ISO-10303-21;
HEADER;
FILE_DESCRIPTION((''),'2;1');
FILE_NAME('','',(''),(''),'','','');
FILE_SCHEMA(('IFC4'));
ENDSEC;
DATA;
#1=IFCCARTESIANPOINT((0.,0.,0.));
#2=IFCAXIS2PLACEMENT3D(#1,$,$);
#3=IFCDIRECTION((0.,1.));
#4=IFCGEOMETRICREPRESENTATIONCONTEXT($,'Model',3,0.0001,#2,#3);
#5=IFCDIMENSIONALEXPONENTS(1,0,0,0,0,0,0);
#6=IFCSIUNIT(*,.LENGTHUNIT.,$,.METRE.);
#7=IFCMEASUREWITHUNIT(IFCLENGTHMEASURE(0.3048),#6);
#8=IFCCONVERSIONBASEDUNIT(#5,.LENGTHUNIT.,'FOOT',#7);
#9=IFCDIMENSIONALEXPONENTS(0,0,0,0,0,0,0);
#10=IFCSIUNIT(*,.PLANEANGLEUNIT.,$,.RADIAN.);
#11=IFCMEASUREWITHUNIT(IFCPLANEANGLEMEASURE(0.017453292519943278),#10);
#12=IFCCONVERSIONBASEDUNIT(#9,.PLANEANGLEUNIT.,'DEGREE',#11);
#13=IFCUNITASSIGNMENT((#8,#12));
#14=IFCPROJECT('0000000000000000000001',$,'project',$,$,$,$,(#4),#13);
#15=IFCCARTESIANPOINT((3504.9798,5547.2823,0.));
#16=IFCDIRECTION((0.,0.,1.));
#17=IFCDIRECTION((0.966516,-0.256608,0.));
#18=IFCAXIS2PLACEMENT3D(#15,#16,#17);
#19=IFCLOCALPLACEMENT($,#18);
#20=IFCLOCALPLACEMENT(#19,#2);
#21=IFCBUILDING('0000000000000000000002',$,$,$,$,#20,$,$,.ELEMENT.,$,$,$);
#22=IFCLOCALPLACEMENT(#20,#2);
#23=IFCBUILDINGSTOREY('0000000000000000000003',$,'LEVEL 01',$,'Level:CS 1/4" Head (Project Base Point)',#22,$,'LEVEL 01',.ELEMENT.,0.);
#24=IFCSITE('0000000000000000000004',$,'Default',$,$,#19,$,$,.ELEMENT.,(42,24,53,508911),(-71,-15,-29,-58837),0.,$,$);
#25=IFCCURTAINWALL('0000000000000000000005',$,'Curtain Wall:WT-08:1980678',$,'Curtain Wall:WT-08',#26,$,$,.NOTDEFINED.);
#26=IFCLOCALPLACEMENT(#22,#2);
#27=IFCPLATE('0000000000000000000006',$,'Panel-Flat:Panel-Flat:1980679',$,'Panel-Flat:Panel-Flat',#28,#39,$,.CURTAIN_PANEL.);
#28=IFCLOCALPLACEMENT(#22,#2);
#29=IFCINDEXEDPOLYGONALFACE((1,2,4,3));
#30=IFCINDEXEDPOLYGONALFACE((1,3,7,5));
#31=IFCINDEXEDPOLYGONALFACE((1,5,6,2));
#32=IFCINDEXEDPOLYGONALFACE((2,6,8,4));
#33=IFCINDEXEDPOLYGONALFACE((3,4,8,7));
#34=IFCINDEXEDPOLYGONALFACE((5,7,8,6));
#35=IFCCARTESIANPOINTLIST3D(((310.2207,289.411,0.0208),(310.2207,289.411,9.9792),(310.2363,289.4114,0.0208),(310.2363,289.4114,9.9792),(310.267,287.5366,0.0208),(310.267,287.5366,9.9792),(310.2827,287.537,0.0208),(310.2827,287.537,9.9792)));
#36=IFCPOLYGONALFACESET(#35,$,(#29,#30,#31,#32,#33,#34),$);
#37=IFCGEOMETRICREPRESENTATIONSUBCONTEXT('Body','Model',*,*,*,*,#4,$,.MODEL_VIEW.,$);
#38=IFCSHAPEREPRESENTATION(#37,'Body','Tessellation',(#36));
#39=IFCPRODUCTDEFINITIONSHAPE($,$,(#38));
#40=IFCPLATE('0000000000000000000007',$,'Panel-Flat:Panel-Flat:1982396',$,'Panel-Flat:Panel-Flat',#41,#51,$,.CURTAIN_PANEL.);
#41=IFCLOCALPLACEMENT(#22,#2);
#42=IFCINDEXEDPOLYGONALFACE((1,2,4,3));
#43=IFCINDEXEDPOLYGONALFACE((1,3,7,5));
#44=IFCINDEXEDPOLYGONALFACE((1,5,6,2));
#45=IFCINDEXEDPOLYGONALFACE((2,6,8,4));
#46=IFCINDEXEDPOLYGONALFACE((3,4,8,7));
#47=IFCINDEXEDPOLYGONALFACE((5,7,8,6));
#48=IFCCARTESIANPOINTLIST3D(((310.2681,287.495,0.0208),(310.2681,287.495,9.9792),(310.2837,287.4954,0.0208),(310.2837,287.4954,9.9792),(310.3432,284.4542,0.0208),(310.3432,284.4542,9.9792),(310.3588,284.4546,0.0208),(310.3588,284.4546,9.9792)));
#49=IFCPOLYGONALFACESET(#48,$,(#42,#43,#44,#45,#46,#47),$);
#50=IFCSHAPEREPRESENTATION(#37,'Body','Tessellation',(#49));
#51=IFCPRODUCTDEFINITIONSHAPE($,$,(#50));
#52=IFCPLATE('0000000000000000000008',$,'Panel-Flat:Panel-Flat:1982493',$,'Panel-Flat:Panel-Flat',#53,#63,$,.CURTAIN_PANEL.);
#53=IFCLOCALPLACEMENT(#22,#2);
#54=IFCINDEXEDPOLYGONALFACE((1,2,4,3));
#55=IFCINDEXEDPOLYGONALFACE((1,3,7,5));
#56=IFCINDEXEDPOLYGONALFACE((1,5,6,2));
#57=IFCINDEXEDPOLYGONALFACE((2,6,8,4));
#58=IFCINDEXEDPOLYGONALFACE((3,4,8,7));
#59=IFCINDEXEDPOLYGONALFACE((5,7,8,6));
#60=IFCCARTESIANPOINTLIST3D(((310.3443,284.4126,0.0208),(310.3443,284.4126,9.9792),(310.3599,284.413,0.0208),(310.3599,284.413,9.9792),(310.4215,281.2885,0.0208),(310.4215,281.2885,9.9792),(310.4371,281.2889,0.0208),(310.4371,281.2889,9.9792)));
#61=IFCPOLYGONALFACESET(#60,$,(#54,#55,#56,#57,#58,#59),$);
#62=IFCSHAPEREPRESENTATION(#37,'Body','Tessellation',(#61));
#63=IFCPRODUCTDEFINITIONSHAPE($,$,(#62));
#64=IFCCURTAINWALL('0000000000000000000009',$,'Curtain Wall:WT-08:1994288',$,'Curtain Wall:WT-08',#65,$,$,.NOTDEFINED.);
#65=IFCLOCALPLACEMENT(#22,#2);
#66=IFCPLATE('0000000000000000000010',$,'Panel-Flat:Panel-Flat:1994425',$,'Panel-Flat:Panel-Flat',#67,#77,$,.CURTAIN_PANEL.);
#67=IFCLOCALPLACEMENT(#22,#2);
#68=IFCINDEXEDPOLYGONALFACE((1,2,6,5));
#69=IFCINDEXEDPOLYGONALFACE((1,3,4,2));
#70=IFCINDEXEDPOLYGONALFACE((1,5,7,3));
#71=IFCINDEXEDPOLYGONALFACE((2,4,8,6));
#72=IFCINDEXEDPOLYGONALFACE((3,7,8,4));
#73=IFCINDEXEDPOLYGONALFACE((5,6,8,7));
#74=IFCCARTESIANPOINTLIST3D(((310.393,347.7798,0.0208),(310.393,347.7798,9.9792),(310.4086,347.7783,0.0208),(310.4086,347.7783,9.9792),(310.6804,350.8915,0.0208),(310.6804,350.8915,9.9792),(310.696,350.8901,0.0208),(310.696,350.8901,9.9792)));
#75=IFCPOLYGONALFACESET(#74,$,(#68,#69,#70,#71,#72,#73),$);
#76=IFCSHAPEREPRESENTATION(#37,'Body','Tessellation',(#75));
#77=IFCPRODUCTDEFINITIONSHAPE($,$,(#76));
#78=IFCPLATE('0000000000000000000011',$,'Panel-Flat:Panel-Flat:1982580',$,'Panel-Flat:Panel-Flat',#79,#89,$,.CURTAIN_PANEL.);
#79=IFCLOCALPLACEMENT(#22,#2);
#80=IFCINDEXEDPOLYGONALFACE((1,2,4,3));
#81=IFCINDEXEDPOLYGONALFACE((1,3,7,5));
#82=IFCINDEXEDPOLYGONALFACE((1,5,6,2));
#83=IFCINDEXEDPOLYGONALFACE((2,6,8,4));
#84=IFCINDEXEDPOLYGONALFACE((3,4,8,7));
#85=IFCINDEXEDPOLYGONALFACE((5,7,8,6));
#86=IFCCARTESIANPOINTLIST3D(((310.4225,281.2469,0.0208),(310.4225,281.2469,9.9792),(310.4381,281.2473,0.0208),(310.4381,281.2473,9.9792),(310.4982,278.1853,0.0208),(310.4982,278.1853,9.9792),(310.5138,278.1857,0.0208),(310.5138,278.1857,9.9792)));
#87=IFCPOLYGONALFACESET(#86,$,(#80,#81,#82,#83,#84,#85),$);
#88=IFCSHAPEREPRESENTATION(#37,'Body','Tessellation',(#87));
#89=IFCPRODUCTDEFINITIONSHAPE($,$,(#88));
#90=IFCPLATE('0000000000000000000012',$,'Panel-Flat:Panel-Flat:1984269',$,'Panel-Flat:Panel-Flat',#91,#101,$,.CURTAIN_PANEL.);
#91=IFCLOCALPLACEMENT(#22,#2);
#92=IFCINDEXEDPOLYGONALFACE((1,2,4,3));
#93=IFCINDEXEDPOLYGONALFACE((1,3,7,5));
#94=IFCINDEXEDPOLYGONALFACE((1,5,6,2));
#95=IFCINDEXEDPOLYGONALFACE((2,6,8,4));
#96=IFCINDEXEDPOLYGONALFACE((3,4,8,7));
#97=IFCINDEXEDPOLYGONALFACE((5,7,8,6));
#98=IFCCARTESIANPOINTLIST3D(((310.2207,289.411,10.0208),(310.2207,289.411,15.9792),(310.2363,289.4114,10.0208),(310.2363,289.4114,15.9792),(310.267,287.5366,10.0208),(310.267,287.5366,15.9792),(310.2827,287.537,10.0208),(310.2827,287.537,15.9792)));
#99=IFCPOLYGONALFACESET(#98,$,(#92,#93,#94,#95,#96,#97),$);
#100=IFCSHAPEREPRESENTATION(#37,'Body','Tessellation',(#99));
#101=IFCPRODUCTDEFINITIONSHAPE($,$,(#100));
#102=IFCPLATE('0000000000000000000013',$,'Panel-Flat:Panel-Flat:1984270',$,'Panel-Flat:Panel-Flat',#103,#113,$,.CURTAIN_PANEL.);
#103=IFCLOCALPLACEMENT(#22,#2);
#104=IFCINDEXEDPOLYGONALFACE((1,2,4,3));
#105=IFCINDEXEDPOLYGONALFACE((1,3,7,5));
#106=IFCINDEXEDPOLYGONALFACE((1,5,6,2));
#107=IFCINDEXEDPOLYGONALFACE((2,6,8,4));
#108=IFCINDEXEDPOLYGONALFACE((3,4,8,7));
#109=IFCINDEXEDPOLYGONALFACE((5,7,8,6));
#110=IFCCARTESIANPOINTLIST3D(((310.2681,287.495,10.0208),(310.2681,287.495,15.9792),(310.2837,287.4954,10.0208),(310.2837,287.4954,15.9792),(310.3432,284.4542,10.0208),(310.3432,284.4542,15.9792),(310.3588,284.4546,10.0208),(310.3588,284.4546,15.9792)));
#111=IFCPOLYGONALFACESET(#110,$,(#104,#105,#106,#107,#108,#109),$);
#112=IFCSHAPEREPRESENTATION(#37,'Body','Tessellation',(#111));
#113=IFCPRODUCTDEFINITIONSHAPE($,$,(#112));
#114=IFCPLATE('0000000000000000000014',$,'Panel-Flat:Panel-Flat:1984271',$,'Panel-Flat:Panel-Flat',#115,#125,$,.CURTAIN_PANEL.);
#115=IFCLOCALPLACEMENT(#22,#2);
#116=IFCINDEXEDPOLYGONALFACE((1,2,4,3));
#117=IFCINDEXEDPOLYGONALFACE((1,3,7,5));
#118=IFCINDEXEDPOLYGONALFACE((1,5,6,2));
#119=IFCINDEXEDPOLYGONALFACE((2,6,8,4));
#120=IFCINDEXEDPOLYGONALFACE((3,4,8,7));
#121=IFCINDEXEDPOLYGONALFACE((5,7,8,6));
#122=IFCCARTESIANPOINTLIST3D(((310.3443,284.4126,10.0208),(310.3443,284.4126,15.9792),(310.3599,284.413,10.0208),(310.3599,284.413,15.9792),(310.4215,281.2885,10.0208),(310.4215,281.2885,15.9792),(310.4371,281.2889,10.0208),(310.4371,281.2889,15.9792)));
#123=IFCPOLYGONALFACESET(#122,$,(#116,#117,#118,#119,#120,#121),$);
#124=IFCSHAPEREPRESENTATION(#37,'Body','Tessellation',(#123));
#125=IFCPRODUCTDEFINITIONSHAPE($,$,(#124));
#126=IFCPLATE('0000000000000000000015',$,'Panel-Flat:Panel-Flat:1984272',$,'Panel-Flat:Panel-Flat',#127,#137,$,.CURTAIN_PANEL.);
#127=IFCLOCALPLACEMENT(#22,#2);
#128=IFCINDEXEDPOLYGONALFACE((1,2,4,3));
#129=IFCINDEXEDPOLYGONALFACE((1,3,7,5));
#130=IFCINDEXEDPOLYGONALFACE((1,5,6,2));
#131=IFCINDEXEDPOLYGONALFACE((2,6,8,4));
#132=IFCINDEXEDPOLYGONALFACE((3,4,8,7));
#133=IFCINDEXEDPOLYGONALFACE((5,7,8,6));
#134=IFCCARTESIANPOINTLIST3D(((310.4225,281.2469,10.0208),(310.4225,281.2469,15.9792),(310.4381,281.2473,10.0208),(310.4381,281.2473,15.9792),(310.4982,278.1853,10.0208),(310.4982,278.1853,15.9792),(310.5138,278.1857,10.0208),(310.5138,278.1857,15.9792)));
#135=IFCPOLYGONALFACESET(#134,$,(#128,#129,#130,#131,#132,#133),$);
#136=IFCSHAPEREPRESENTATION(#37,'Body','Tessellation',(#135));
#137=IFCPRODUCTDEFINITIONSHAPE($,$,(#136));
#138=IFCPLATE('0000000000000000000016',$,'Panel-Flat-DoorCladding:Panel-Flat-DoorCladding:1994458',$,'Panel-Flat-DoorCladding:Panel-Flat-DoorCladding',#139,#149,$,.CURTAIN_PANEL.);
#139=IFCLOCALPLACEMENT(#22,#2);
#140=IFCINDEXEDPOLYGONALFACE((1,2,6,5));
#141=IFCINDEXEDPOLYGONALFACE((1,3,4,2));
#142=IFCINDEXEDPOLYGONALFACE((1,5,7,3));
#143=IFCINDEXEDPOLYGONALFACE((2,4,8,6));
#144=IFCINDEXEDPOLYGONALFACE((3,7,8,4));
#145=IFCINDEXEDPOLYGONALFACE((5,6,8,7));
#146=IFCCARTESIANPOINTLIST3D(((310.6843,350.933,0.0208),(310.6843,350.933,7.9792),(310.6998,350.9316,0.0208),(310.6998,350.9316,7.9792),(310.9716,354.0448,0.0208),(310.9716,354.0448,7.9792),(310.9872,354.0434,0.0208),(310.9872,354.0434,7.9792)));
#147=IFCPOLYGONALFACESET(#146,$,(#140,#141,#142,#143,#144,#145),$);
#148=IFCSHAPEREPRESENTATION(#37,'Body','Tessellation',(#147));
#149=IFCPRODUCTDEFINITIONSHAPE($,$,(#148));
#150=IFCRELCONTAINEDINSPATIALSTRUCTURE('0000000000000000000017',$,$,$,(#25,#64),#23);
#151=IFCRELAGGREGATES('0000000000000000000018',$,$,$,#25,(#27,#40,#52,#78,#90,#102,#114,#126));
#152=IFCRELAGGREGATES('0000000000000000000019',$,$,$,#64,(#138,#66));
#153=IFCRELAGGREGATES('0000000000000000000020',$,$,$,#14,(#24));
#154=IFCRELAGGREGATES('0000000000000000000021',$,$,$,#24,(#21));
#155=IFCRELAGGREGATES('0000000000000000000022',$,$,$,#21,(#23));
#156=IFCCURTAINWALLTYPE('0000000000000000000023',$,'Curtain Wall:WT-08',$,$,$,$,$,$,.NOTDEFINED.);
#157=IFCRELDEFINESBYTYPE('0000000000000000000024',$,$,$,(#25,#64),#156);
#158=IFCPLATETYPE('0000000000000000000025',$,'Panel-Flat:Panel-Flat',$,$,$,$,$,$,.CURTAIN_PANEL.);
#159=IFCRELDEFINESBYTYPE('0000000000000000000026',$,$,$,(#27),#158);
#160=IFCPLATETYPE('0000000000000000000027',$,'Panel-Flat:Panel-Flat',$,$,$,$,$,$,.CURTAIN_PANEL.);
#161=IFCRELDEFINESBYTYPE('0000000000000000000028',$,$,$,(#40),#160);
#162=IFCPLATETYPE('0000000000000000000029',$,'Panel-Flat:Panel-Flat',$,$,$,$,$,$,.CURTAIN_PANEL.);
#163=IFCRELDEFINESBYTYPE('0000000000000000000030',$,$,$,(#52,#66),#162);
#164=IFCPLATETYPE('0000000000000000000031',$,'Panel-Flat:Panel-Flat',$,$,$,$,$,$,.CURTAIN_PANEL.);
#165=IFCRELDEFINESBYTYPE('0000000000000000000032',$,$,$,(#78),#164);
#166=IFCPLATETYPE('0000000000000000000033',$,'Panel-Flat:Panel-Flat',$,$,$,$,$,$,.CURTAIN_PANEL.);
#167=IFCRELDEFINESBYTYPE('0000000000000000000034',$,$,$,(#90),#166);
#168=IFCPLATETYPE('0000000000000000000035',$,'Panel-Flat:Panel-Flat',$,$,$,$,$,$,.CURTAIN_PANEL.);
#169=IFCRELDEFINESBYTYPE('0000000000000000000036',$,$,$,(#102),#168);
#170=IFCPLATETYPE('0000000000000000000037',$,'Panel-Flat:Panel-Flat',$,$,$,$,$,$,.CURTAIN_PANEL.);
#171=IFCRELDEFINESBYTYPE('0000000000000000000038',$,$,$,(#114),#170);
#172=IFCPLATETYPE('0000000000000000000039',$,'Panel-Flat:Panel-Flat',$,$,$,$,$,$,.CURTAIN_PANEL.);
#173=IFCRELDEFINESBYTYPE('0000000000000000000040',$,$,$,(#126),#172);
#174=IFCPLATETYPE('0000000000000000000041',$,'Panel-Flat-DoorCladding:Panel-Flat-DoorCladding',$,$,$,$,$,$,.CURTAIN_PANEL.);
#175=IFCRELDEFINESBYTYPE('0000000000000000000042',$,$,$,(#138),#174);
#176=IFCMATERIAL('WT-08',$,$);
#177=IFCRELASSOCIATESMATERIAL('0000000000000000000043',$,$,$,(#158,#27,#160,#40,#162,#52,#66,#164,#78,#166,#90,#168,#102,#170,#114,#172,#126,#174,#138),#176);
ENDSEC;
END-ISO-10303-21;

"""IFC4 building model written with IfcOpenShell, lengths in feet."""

from ifc_helpers import new_model, entity, si_unit, converted_unit, direction, frame, origin, place, context, subcontext, project, spatial, indexed_curve, outline, extrude, source, transform, mapped, material, type_object, type_shapes, element, aggregate, save


model = new_model("IFC4")

# Units and contexts
model_context = context("Model", 3, precision=0.0001, world=origin(), true_north=direction((0.0, 1.0)))
body_context = subcontext(model_context, "Body", "Model", "MODEL_VIEW")
ifc_project = project(units=[converted_unit("LENGTHUNIT", "FOOT", entity("IfcLengthMeasure", 0.3048), si_unit("LENGTHUNIT", "METRE"), dimensions=[1, 0, 0, 0, 0, 0, 0]), converted_unit("PLANEANGLEUNIT", "DEGREE", entity("IfcPlaneAngleMeasure", 0.017453292519943278), si_unit("PLANEANGLEUNIT", "RADIAN"), dimensions=[0, 0, 0, 0, 0, 0, 0])], contexts=[model_context])

# Site, building, storey
site_placement = place(None, frame((3504.9798, 5547.2823, 0.0), z_axis=(0.0, 0.0, 1.0), x_axis=(0.966516, -0.256608, 0.0)))
site = spatial("IfcSite", under=ifc_project, at=site_placement, Name="Default", CompositionType="ELEMENT", RefLatitude=(42, 24, 53, 508911), RefLongitude=(-71, -15, -29, -58837), RefElevation=0.0)
building_placement = place(site_placement, origin())
building = spatial("IfcBuilding", under=site, at=building_placement, CompositionType="ELEMENT")
storey_placement = place(building_placement, origin())
storey = spatial("IfcBuildingStorey", under=building, at=storey_placement, Name="LEVEL 01", ObjectType="Level:CS 1/4\" Head (Project Base Point)", LongName="LEVEL 01", CompositionType="ELEMENT", Elevation=0.0)

# Curtain wall, plates
curtain_wall_type_1 = type_object("IfcCurtainWallType", Name="Curtain Wall:WT-08", PredefinedType="NOTDEFINED")
curtain_wall_1_placement = place(storey_placement, origin())
curtain_wall_1 = element("IfcCurtainWall", 1, at=curtain_wall_1_placement, inside=storey, type_object=curtain_wall_type_1, Name="Curtain Wall:WT-08:1980678", ObjectType="Curtain Wall:WT-08", PredefinedType="NOTDEFINED")
ifc_material_1 = material(Name="WT-08")
plate_type_1 = type_object("IfcPlateType", Name="Panel-Flat:Panel-Flat", PredefinedType="CURTAIN_PANEL", material=ifc_material_1)
shared_shape_1 = source(origin(), body_context, "Body", "SweptSolid", [
    extrude(outline(indexed_curve([(-0.0078, -0.9375), (0.0078, -0.9375), (0.0078, 0.9375), (-0.0078, 0.9375), (-0.0078, -0.9375)], self_intersect=False)), frame((0.0, -0.0078, 0.0208), z_axis=(0.0, 0.0, 1.0), x_axis=(0.0, -1.0, 0.0)), (0.0, 0.0, 1.0), 9.9583),
])
type_shapes(plate_type_1, [shared_shape_1])
plate_1_placement = place(curtain_wall_1_placement, frame((310.2595, 288.4742, 0.0), z_axis=(0.0, 0.0, 1.0), x_axis=(0.024711, -0.999695, 0.0)))
plate_1 = element("IfcPlate", 2, at=plate_1_placement, type_object=plate_type_1, material=ifc_material_1, Name="Panel-Flat:Panel-Flat:1980679", ObjectType="Panel-Flat:Panel-Flat", PredefinedType="CURTAIN_PANEL", context=body_context, shape_type="MappedRepresentation", body=[
    mapped(shared_shape_1, transform((0.0, 0.0, 0.0), scale=1.0)),
])
plate_type_2 = type_object("IfcPlateType", Name="Panel-Flat:Panel-Flat", PredefinedType="CURTAIN_PANEL", material=ifc_material_1)
shared_shape_2 = source(origin(), body_context, "Body", "SweptSolid", [
    extrude(outline(indexed_curve([(-0.0078, -1.5208), (0.0078, -1.5208), (0.0078, 1.5208), (-0.0078, 1.5208), (-0.0078, -1.5208)], self_intersect=False)), frame((0.0, -0.0078, 0.0208), z_axis=(0.0, 0.0, 1.0), x_axis=(0.0, -1.0, 0.0)), (0.0, 0.0, 1.0), 9.9583),
])
type_shapes(plate_type_2, [shared_shape_2])
plate_2_placement = place(curtain_wall_1_placement, frame((310.3213, 285.975, 0.0), z_axis=(0.0, 0.0, 1.0), x_axis=(0.024711, -0.999695, 0.0)))
plate_2 = element("IfcPlate", 3, at=plate_2_placement, type_object=plate_type_2, material=ifc_material_1, Name="Panel-Flat:Panel-Flat:1982396", ObjectType="Panel-Flat:Panel-Flat", PredefinedType="CURTAIN_PANEL", context=body_context, shape_type="MappedRepresentation", body=[
    mapped(shared_shape_2, transform((0.0, 0.0, 0.0), scale=1.0)),
])
plate_type_3 = type_object("IfcPlateType", Name="Panel-Flat:Panel-Flat", PredefinedType="CURTAIN_PANEL", material=ifc_material_1)
shared_shape_3 = source(origin(), body_context, "Body", "SweptSolid", [
    extrude(outline(indexed_curve([(-0.0078, -1.5625), (0.0078, -1.5625), (0.0078, 1.5625), (-0.0078, 1.5625), (-0.0078, -1.5625)], self_intersect=False)), frame((0.0, -0.0078, 0.0208), z_axis=(0.0, 0.0, 1.0), x_axis=(0.0, -1.0, 0.0)), (0.0, 0.0, 1.0), 9.9583),
])
type_shapes(plate_type_3, [shared_shape_3])
plate_3_placement = place(curtain_wall_1_placement, frame((310.3985, 282.8509, 0.0), z_axis=(0.0, 0.0, 1.0), x_axis=(0.024711, -0.999695, 0.0)))
plate_3 = element("IfcPlate", 4, at=plate_3_placement, type_object=plate_type_3, material=ifc_material_1, Name="Panel-Flat:Panel-Flat:1982493", ObjectType="Panel-Flat:Panel-Flat", PredefinedType="CURTAIN_PANEL", context=body_context, shape_type="MappedRepresentation", body=[
    mapped(shared_shape_3, transform((0.0, 0.0, 0.0), scale=1.0)),
])

# Curtain wall, plate
curtain_wall_2_placement = place(storey_placement, origin())
curtain_wall_2 = element("IfcCurtainWall", 5, at=curtain_wall_2_placement, inside=storey, type_object=curtain_wall_type_1, Name="Curtain Wall:WT-08:1994288", ObjectType="Curtain Wall:WT-08", PredefinedType="NOTDEFINED")
plate_4_placement = place(curtain_wall_2_placement, frame((310.5523, 349.3342, 0.0), z_axis=(0.0, 0.0, 1.0), x_axis=(-0.091962, -0.995763, 0.0)))
plate_4 = element("IfcPlate", 6, at=plate_4_placement, type_object=plate_type_3, material=ifc_material_1, Name="Panel-Flat:Panel-Flat:1994425", ObjectType="Panel-Flat:Panel-Flat", PredefinedType="CURTAIN_PANEL", context=body_context, shape_type="MappedRepresentation", body=[
    mapped(shared_shape_3, transform((0.0, 0.0, 0.0), scale=1.0)),
])

# Plates
plate_type_4 = type_object("IfcPlateType", Name="Panel-Flat:Panel-Flat", PredefinedType="CURTAIN_PANEL", material=ifc_material_1)
shared_shape_4 = source(origin(), body_context, "Body", "SweptSolid", [
    extrude(outline(indexed_curve([(-0.0078, -1.5313), (0.0078, -1.5313), (0.0078, 1.5313), (-0.0078, 1.5313), (-0.0078, -1.5313)], self_intersect=False)), frame((0.0, -0.0078, 0.0208), z_axis=(0.0, 0.0, 1.0), x_axis=(0.0, -1.0, 0.0)), (0.0, 0.0, 1.0), 9.9583),
])
type_shapes(plate_type_4, [shared_shape_4])
plate_5_placement = place(curtain_wall_1_placement, frame((310.476, 279.7165, 0.0), z_axis=(0.0, 0.0, 1.0), x_axis=(0.024711, -0.999695, 0.0)))
plate_5 = element("IfcPlate", 7, at=plate_5_placement, type_object=plate_type_4, material=ifc_material_1, Name="Panel-Flat:Panel-Flat:1982580", ObjectType="Panel-Flat:Panel-Flat", PredefinedType="CURTAIN_PANEL", context=body_context, shape_type="MappedRepresentation", body=[
    mapped(shared_shape_4, transform((0.0, 0.0, 0.0), scale=1.0)),
])
plate_type_5 = type_object("IfcPlateType", Name="Panel-Flat:Panel-Flat", PredefinedType="CURTAIN_PANEL", material=ifc_material_1)
shared_shape_5 = source(origin(), body_context, "Body", "SweptSolid", [
    extrude(outline(indexed_curve([(-0.0078, -0.9375), (0.0078, -0.9375), (0.0078, 0.9375), (-0.0078, 0.9375), (-0.0078, -0.9375)], self_intersect=False)), frame((0.0, -0.0078, 0.0208), z_axis=(0.0, 0.0, 1.0), x_axis=(0.0, -1.0, 0.0)), (0.0, 0.0, 1.0), 5.9583),
])
type_shapes(plate_type_5, [shared_shape_5])
plate_6_placement = place(curtain_wall_1_placement, frame((310.2595, 288.4742, 10.0), z_axis=(0.0, 0.0, 1.0), x_axis=(0.024711, -0.999695, 0.0)))
plate_6 = element("IfcPlate", 8, at=plate_6_placement, type_object=plate_type_5, material=ifc_material_1, Name="Panel-Flat:Panel-Flat:1984269", ObjectType="Panel-Flat:Panel-Flat", PredefinedType="CURTAIN_PANEL", context=body_context, shape_type="MappedRepresentation", body=[
    mapped(shared_shape_5, transform((0.0, 0.0, 0.0), scale=1.0)),
])
plate_type_6 = type_object("IfcPlateType", Name="Panel-Flat:Panel-Flat", PredefinedType="CURTAIN_PANEL", material=ifc_material_1)
shared_shape_6 = source(origin(), body_context, "Body", "SweptSolid", [
    extrude(outline(indexed_curve([(-0.0078, -1.5208), (0.0078, -1.5208), (0.0078, 1.5208), (-0.0078, 1.5208), (-0.0078, -1.5208)], self_intersect=False)), frame((0.0, -0.0078, 0.0208), z_axis=(0.0, 0.0, 1.0), x_axis=(0.0, -1.0, 0.0)), (0.0, 0.0, 1.0), 5.9583),
])
type_shapes(plate_type_6, [shared_shape_6])
plate_7_placement = place(curtain_wall_1_placement, frame((310.3213, 285.975, 10.0), z_axis=(0.0, 0.0, 1.0), x_axis=(0.024711, -0.999695, 0.0)))
plate_7 = element("IfcPlate", 9, at=plate_7_placement, type_object=plate_type_6, material=ifc_material_1, Name="Panel-Flat:Panel-Flat:1984270", ObjectType="Panel-Flat:Panel-Flat", PredefinedType="CURTAIN_PANEL", context=body_context, shape_type="MappedRepresentation", body=[
    mapped(shared_shape_6, transform((0.0, 0.0, 0.0), scale=1.0)),
])
plate_type_7 = type_object("IfcPlateType", Name="Panel-Flat:Panel-Flat", PredefinedType="CURTAIN_PANEL", material=ifc_material_1)
shared_shape_7 = source(origin(), body_context, "Body", "SweptSolid", [
    extrude(outline(indexed_curve([(-0.0078, -1.5625), (0.0078, -1.5625), (0.0078, 1.5625), (-0.0078, 1.5625), (-0.0078, -1.5625)], self_intersect=False)), frame((0.0, -0.0078, 0.0208), z_axis=(0.0, 0.0, 1.0), x_axis=(0.0, -1.0, 0.0)), (0.0, 0.0, 1.0), 5.9583),
])
type_shapes(plate_type_7, [shared_shape_7])
plate_8_placement = place(curtain_wall_1_placement, frame((310.3985, 282.8509, 10.0), z_axis=(0.0, 0.0, 1.0), x_axis=(0.024711, -0.999695, 0.0)))
plate_8 = element("IfcPlate", 10, at=plate_8_placement, type_object=plate_type_7, material=ifc_material_1, Name="Panel-Flat:Panel-Flat:1984271", ObjectType="Panel-Flat:Panel-Flat", PredefinedType="CURTAIN_PANEL", context=body_context, shape_type="MappedRepresentation", body=[
    mapped(shared_shape_7, transform((0.0, 0.0, 0.0), scale=1.0)),
])
plate_type_8 = type_object("IfcPlateType", Name="Panel-Flat:Panel-Flat", PredefinedType="CURTAIN_PANEL", material=ifc_material_1)
shared_shape_8 = source(origin(), body_context, "Body", "SweptSolid", [
    extrude(outline(indexed_curve([(-0.0078, -1.5313), (0.0078, -1.5313), (0.0078, 1.5313), (-0.0078, 1.5313), (-0.0078, -1.5313)], self_intersect=False)), frame((0.0, -0.0078, 0.0208), z_axis=(0.0, 0.0, 1.0), x_axis=(0.0, -1.0, 0.0)), (0.0, 0.0, 1.0), 5.9583),
])
type_shapes(plate_type_8, [shared_shape_8])
plate_9_placement = place(curtain_wall_1_placement, frame((310.476, 279.7165, 10.0), z_axis=(0.0, 0.0, 1.0), x_axis=(0.024711, -0.999695, 0.0)))
plate_9 = element("IfcPlate", 11, at=plate_9_placement, type_object=plate_type_8, material=ifc_material_1, Name="Panel-Flat:Panel-Flat:1984272", ObjectType="Panel-Flat:Panel-Flat", PredefinedType="CURTAIN_PANEL", context=body_context, shape_type="MappedRepresentation", body=[
    mapped(shared_shape_8, transform((0.0, 0.0, 0.0), scale=1.0)),
])
aggregate(curtain_wall_1, [plate_1, plate_2, plate_3, plate_5, plate_6, plate_7, plate_8, plate_9])
plate_type_9 = type_object("IfcPlateType", Name="Panel-Flat-DoorCladding:Panel-Flat-DoorCladding", PredefinedType="CURTAIN_PANEL", material=ifc_material_1)
shared_shape_9 = source(origin(), body_context, "Body", "SweptSolid", [
    extrude(outline(indexed_curve([(-0.0078, -1.5625), (0.0078, -1.5625), (0.0078, 1.5625), (-0.0078, 1.5625), (-0.0078, -1.5625)], self_intersect=False)), frame((0.0, -0.0078, 0.0208), z_axis=(0.0, 0.0, 1.0), x_axis=(0.0, -1.0, 0.0)), (0.0, 0.0, 1.0), 7.9583),
])
type_shapes(plate_type_9, [shared_shape_9])
plate_10_placement = place(curtain_wall_2_placement, frame((310.8435, 352.4875, 0.0), z_axis=(0.0, 0.0, 1.0), x_axis=(-0.091962, -0.995763, 0.0)))
plate_10 = element("IfcPlate", 12, at=plate_10_placement, type_object=plate_type_9, material=ifc_material_1, Name="Panel-Flat-DoorCladding:Panel-Flat-DoorCladding:1994458", ObjectType="Panel-Flat-DoorCladding:Panel-Flat-DoorCladding", PredefinedType="CURTAIN_PANEL", context=body_context, shape_type="MappedRepresentation", body=[
    mapped(shared_shape_9, transform((0.0, 0.0, 0.0), scale=1.0)),
])
aggregate(curtain_wall_2, [plate_10, plate_4])

save(model, "model.ifc")
